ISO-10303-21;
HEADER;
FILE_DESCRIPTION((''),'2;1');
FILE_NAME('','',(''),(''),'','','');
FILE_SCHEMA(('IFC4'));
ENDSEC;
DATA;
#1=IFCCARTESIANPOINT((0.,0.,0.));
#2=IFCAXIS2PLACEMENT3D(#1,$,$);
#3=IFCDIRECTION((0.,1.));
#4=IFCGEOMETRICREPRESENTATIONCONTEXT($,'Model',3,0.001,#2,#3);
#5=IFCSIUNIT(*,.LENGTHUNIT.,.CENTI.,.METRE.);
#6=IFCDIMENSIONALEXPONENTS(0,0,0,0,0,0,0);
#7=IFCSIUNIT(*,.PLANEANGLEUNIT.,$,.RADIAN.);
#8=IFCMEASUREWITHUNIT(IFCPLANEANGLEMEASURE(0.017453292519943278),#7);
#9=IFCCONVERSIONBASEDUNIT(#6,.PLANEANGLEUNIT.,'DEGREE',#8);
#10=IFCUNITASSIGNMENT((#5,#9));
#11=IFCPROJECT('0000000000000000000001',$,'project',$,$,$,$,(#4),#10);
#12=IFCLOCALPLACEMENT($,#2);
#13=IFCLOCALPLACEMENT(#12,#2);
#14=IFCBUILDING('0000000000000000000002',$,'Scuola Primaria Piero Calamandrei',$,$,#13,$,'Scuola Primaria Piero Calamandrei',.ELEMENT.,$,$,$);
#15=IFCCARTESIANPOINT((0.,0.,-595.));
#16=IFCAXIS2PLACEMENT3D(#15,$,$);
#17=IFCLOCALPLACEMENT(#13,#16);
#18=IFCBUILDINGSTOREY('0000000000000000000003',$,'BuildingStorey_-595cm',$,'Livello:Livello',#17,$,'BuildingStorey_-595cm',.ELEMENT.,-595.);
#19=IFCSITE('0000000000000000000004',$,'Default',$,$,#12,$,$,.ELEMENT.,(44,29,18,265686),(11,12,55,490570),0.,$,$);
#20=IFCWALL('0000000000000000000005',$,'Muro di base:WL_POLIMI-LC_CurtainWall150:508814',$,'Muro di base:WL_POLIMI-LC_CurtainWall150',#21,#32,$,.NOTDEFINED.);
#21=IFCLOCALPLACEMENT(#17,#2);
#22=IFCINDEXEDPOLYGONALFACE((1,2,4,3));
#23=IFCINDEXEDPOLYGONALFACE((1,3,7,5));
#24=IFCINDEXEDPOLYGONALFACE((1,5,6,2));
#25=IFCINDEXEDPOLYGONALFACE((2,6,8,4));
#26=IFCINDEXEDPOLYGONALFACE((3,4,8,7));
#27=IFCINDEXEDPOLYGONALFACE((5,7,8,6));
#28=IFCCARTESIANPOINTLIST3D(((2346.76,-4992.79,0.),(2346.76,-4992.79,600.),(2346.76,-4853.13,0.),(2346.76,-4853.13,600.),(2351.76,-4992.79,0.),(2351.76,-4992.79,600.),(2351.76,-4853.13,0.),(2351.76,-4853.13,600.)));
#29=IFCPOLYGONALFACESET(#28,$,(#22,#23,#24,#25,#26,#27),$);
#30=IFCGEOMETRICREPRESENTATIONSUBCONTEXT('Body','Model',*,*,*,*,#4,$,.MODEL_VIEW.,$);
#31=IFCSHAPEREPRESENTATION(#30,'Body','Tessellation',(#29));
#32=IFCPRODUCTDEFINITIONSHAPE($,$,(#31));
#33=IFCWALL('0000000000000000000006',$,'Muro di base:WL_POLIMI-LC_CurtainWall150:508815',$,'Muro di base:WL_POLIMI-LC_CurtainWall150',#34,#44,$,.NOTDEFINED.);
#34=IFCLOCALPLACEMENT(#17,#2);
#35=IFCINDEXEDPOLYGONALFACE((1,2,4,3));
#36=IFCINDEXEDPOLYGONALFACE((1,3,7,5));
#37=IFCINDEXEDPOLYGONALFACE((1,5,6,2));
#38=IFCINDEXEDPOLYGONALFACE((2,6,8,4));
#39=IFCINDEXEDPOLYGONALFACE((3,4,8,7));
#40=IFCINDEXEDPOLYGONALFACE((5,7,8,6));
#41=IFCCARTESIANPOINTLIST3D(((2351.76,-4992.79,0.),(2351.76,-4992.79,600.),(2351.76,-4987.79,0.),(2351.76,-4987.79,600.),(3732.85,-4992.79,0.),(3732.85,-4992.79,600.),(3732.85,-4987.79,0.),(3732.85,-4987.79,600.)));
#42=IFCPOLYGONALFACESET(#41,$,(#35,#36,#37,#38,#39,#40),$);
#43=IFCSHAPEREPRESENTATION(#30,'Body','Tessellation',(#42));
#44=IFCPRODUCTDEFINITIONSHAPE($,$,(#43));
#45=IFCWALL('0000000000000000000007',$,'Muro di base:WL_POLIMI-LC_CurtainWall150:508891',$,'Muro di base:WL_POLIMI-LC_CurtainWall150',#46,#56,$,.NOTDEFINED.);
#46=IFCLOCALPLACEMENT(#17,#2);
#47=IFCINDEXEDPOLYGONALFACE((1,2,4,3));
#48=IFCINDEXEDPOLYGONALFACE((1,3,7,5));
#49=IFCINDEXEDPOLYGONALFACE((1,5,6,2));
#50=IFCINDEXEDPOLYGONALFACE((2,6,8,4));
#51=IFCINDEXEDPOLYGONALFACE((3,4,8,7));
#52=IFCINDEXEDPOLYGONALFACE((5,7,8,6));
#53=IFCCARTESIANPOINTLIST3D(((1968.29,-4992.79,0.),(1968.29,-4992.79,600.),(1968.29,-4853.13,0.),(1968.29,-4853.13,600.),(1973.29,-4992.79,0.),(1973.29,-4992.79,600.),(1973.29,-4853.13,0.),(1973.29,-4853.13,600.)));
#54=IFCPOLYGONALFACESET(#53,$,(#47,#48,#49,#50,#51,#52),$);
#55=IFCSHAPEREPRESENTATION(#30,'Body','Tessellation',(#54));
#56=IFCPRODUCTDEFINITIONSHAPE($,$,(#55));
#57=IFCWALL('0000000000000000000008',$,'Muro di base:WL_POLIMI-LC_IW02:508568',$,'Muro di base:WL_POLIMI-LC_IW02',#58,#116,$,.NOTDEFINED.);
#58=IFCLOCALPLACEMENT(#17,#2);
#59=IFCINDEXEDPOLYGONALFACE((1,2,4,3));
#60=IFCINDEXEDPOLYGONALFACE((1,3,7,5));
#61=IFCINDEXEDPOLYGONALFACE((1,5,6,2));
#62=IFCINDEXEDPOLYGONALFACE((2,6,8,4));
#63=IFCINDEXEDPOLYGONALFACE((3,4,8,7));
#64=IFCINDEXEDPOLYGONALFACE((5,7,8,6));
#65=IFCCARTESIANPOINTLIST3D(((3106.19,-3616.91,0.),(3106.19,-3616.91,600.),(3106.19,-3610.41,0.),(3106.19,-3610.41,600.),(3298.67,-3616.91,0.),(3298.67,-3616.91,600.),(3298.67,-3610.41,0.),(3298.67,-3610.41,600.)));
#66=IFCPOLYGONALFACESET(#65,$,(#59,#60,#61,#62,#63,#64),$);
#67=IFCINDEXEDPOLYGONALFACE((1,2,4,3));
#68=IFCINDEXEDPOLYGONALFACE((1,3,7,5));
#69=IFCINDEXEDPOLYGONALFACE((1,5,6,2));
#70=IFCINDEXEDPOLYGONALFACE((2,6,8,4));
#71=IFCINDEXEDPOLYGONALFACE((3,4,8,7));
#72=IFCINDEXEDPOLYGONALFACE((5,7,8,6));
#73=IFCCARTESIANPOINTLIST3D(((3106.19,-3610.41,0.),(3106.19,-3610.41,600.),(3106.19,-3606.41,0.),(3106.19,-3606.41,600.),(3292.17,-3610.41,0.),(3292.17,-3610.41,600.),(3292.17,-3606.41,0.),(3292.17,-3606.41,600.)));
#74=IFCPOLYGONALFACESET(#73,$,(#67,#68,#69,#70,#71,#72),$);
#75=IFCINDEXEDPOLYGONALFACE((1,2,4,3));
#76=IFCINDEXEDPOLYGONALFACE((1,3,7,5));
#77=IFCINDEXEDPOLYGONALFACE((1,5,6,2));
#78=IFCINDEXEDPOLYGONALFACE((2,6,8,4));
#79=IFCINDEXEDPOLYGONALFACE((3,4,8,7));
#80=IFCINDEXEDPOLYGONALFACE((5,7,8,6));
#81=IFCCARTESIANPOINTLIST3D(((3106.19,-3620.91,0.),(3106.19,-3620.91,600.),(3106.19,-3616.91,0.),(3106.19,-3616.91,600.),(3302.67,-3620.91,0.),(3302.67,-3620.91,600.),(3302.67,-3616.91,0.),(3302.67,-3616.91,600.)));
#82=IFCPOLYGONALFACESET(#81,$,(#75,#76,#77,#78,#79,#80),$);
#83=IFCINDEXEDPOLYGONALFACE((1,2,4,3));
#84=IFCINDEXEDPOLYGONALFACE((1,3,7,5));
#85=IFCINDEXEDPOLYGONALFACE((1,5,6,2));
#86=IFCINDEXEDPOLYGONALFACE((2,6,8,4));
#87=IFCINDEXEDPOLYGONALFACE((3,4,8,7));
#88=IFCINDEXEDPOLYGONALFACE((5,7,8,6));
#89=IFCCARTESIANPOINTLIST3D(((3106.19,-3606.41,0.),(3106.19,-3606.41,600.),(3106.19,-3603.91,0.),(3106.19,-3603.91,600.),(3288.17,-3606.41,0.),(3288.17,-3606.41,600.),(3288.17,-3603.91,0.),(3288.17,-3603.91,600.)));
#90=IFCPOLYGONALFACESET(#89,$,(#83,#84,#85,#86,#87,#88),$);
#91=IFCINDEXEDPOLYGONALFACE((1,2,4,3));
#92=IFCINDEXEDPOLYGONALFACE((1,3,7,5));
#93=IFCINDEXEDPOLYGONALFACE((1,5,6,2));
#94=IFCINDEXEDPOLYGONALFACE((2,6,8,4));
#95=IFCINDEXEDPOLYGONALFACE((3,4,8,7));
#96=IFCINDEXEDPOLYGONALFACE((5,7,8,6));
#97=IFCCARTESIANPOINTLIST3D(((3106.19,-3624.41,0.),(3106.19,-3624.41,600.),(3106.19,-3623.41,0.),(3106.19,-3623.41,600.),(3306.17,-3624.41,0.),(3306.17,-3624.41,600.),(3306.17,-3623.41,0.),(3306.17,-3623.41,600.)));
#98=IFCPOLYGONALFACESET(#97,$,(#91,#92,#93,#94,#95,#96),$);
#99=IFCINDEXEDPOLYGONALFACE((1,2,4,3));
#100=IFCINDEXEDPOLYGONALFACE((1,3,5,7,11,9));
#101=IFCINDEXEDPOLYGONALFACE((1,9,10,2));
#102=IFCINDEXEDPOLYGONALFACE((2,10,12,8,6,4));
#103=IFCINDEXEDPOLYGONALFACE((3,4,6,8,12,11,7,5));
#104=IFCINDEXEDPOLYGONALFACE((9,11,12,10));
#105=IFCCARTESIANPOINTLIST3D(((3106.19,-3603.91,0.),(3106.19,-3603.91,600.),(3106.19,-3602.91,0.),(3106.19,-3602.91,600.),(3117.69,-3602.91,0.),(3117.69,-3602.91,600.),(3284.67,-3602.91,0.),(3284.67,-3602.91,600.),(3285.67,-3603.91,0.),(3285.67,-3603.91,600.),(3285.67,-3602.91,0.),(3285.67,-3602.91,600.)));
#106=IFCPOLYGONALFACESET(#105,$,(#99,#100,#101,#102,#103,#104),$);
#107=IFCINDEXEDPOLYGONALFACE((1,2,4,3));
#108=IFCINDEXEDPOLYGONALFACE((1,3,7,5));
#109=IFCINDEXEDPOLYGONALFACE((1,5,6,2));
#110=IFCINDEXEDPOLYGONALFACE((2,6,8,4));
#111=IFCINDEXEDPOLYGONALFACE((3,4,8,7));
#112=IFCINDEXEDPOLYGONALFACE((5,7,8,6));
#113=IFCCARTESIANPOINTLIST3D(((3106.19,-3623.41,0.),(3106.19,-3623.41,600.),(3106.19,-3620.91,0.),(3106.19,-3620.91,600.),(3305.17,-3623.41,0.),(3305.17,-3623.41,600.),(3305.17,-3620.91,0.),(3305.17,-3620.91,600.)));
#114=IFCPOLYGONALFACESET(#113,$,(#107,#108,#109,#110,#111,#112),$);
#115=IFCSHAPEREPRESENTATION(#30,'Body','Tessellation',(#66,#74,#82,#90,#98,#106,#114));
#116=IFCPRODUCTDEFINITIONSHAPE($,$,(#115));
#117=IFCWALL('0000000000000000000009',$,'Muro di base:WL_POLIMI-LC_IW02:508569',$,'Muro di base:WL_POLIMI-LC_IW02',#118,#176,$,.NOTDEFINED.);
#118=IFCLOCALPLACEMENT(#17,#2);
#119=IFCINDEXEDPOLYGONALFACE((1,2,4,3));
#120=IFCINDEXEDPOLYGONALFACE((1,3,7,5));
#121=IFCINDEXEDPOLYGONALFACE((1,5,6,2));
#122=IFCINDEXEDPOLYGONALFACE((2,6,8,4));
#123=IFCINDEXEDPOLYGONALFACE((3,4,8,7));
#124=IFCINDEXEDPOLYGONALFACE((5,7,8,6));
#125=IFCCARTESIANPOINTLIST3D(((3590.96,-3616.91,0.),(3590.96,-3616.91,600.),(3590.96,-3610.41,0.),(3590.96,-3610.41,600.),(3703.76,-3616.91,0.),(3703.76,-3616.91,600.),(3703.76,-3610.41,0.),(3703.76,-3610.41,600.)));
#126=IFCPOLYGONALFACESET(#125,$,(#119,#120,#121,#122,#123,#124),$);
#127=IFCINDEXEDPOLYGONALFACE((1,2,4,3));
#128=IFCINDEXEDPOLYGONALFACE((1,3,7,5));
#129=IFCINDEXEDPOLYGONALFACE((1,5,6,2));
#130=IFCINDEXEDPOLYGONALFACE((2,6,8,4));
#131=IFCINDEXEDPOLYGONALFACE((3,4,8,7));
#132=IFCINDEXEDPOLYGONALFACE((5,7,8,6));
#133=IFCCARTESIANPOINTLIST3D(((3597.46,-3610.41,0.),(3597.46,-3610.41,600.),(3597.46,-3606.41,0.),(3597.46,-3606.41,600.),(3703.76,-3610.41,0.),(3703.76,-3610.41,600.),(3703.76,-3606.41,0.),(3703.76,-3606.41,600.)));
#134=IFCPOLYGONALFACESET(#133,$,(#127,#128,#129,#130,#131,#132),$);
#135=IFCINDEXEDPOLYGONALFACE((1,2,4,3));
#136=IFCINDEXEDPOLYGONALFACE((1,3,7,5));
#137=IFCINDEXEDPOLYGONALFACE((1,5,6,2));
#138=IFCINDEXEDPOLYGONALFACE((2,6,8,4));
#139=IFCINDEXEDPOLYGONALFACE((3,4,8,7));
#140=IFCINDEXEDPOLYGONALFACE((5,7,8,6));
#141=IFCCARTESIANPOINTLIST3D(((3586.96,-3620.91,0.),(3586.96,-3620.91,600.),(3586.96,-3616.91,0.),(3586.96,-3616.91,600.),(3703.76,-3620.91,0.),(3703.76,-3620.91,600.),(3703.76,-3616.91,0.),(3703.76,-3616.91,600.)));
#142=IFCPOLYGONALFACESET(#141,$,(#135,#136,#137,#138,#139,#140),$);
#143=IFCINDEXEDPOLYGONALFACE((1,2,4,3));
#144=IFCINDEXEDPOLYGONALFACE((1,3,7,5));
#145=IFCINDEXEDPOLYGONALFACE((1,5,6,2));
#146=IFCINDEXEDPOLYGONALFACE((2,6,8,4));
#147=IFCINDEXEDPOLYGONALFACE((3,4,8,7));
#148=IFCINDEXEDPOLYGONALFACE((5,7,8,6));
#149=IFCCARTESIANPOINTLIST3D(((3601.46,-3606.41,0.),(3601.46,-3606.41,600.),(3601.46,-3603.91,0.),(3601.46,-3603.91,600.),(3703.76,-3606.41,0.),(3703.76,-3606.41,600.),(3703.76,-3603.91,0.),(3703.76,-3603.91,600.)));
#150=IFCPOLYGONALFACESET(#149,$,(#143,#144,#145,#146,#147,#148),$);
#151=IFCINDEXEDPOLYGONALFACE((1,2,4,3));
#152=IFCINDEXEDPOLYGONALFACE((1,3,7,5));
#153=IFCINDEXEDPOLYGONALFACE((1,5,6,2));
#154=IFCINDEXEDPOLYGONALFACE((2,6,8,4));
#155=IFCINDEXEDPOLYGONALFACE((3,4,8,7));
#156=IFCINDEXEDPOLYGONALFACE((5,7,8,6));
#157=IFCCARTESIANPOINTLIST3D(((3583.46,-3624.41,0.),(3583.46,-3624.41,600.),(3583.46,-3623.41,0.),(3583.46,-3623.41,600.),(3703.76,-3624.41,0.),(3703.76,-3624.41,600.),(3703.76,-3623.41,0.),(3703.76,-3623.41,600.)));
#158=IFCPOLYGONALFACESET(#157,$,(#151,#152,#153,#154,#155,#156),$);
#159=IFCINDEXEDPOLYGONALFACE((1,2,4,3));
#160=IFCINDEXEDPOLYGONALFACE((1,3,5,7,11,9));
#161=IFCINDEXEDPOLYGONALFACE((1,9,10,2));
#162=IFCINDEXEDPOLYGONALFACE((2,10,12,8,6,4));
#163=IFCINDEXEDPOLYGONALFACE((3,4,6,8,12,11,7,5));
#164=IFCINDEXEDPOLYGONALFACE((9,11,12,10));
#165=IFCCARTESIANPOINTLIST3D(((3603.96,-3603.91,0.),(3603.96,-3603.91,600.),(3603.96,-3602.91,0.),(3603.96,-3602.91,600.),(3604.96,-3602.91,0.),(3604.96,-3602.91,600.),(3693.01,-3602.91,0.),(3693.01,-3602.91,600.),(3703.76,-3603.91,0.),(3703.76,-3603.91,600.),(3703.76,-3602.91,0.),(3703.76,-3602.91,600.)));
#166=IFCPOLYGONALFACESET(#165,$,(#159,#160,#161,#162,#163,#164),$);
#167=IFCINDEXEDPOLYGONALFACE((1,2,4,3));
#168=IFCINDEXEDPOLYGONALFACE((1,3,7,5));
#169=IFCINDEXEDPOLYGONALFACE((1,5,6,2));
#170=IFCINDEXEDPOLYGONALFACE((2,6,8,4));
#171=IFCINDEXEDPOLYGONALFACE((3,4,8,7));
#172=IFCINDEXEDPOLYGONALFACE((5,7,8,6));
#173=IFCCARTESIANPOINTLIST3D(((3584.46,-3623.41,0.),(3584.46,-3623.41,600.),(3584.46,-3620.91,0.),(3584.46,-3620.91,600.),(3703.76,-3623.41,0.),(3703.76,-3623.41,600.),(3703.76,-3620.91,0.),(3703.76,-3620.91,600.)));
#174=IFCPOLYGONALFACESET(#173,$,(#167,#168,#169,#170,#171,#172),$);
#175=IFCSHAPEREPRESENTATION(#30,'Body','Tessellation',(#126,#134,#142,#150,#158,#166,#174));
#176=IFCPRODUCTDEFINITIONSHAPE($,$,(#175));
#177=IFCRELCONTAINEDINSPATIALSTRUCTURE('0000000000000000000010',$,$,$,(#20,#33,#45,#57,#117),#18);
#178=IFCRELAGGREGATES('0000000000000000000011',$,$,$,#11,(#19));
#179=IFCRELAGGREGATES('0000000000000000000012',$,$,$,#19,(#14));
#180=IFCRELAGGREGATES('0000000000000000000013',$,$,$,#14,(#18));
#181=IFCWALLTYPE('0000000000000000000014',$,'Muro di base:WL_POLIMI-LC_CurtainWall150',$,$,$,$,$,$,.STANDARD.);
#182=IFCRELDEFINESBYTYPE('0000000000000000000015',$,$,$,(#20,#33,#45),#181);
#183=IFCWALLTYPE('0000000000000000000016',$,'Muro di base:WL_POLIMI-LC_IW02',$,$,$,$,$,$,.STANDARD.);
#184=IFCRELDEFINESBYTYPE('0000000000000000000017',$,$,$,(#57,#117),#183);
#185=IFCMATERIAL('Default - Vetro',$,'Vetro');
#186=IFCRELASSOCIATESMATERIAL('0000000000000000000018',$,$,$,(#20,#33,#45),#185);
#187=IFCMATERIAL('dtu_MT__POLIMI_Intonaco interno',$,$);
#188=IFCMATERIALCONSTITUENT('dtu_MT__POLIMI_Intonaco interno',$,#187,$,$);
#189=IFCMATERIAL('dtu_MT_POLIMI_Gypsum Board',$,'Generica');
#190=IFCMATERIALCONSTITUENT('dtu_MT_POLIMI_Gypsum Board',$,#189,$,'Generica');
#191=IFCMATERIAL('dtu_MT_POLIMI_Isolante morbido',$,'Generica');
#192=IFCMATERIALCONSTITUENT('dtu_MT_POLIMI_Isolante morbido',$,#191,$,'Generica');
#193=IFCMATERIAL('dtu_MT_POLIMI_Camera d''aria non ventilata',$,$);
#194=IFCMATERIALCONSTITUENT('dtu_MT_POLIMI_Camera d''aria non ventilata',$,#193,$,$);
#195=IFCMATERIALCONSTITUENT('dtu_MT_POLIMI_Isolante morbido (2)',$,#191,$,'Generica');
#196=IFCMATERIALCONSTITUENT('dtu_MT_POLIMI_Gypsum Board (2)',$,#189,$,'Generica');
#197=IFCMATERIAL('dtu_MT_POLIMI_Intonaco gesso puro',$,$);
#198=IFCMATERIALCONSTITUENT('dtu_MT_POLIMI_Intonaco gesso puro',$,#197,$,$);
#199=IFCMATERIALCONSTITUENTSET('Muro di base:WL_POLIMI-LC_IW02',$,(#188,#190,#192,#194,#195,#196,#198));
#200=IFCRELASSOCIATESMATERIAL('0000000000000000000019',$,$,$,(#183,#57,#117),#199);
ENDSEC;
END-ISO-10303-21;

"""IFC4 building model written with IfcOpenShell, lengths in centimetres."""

from ifc_helpers import new_model, entity, si_unit, converted_unit, direction, frame, origin, place, context, subcontext, project, spatial, indexed_curve, outline, extrude, material, constituent, constituent_set, type_object, element, save


model = new_model("IFC4")

# Units and contexts
model_context = context("Model", 3, precision=0.001, world=origin(), true_north=direction((0.0, 1.0)))
body_context = subcontext(model_context, "Body", "Model", "MODEL_VIEW")
ifc_project = project(units=[si_unit("LENGTHUNIT", "METRE", prefix="CENTI"), converted_unit("PLANEANGLEUNIT", "DEGREE", entity("IfcPlaneAngleMeasure", 0.017453292519943278), si_unit("PLANEANGLEUNIT", "RADIAN"), dimensions=[0, 0, 0, 0, 0, 0, 0])], contexts=[model_context])

# Site, building, storey
site_placement = place(None, origin())
site = spatial("IfcSite", under=ifc_project, at=site_placement, Name="Default", CompositionType="ELEMENT", RefLatitude=(44, 29, 18, 265686), RefLongitude=(11, 12, 55, 490570), RefElevation=0.0)
building_placement = place(site_placement, origin())
building = spatial("IfcBuilding", under=site, at=building_placement, Name="Scuola Primaria Piero Calamandrei", LongName="Scuola Primaria Piero Calamandrei", CompositionType="ELEMENT")
storey_placement = place(building_placement, frame((0.0, 0.0, -595.0)))
storey = spatial("IfcBuildingStorey", under=building, at=storey_placement, Name="BuildingStorey_-595cm", ObjectType="Livello:Livello", LongName="BuildingStorey_-595cm", CompositionType="ELEMENT", Elevation=-595.0)

# Walls
ifc_material_1 = material(Name="Default - Vetro", Category="Vetro")
wall_type_1 = type_object("IfcWallType", Name="Muro di base:WL_POLIMI-LC_CurtainWall150", PredefinedType="STANDARD")
wall_1_placement = place(storey_placement, frame((2349.26, -4992.79, 0.0), z_axis=(0.0, 0.0, 1.0), x_axis=(0.0, 1.0, 0.0)))
element("IfcWall", 1, at=wall_1_placement, inside=storey, type_object=wall_type_1, material=ifc_material_1, Name="Muro di base:WL_POLIMI-LC_CurtainWall150:508814", ObjectType="Muro di base:WL_POLIMI-LC_CurtainWall150", PredefinedType="NOTDEFINED", context=body_context, shape_type="SweptSolid", body=[
    extrude(outline(indexed_curve([(139.66, 2.5), (0.0, 2.5), (0.0, -2.5), (139.66, -2.5), (139.66, 2.5)], self_intersect=False)), origin(), (0.0, 0.0, 1.0), 600.0),
])
wall_2_placement = place(storey_placement, frame((3732.85, -4990.29, 0.0), z_axis=(0.0, 0.0, 1.0), x_axis=(-1.0, 0.0, 0.0)))
element("IfcWall", 2, at=wall_2_placement, inside=storey, type_object=wall_type_1, material=ifc_material_1, Name="Muro di base:WL_POLIMI-LC_CurtainWall150:508815", ObjectType="Muro di base:WL_POLIMI-LC_CurtainWall150", PredefinedType="NOTDEFINED", context=body_context, shape_type="SweptSolid", body=[
    extrude(outline(indexed_curve([(1381.1, 2.5), (0.0, 2.5), (0.0, -2.5), (1381.1, -2.5), (1381.1, 2.5)], self_intersect=False)), origin(), (0.0, 0.0, 1.0), 600.0),
])
wall_3_placement = place(storey_placement, frame((1970.79, -4992.79, 0.0), z_axis=(0.0, 0.0, 1.0), x_axis=(0.0, 1.0, 0.0)))
element("IfcWall", 3, at=wall_3_placement, inside=storey, type_object=wall_type_1, material=ifc_material_1, Name="Muro di base:WL_POLIMI-LC_CurtainWall150:508891", ObjectType="Muro di base:WL_POLIMI-LC_CurtainWall150", PredefinedType="NOTDEFINED", context=body_context, shape_type="SweptSolid", body=[
    extrude(outline(indexed_curve([(139.66, 2.5), (0.0, 2.5), (0.0, -2.5), (139.66, -2.5), (139.66, 2.5)], self_intersect=False)), origin(), (0.0, 0.0, 1.0), 600.0),
])
ifc_material_2 = material(Name="dtu_MT__POLIMI_Intonaco interno")
ifc_constituent_1 = constituent(ifc_material_2, Name="dtu_MT__POLIMI_Intonaco interno")
ifc_material_3 = material(Name="dtu_MT_POLIMI_Gypsum Board", Category="Generica")
ifc_constituent_2 = constituent(ifc_material_3, Name="dtu_MT_POLIMI_Gypsum Board", Category="Generica")
ifc_material_4 = material(Name="dtu_MT_POLIMI_Isolante morbido", Category="Generica")
ifc_constituent_3 = constituent(ifc_material_4, Name="dtu_MT_POLIMI_Isolante morbido", Category="Generica")
ifc_material_5 = material(Name="dtu_MT_POLIMI_Camera d'aria non ventilata")
ifc_constituent_4 = constituent(ifc_material_5, Name="dtu_MT_POLIMI_Camera d'aria non ventilata")
ifc_constituent_5 = constituent(ifc_material_4, Name="dtu_MT_POLIMI_Isolante morbido (2)", Category="Generica")
ifc_constituent_6 = constituent(ifc_material_3, Name="dtu_MT_POLIMI_Gypsum Board (2)", Category="Generica")
ifc_material_6 = material(Name="dtu_MT_POLIMI_Intonaco gesso puro")
ifc_constituent_7 = constituent(ifc_material_6, Name="dtu_MT_POLIMI_Intonaco gesso puro")
ifc_constituent_set_1 = constituent_set(constituents=[ifc_constituent_1, ifc_constituent_2, ifc_constituent_3, ifc_constituent_4, ifc_constituent_5, ifc_constituent_6, ifc_constituent_7], Name="Muro di base:WL_POLIMI-LC_IW02")
wall_type_2 = type_object("IfcWallType", Name="Muro di base:WL_POLIMI-LC_IW02", PredefinedType="STANDARD", material=ifc_constituent_set_1)
wall_4_placement = place(storey_placement, frame((3106.19, -3613.66, 0.0)))
element("IfcWall", 4, at=wall_4_placement, inside=storey, type_object=wall_type_2, material=ifc_constituent_set_1, Name="Muro di base:WL_POLIMI-LC_IW02:508568", ObjectType="Muro di base:WL_POLIMI-LC_IW02", PredefinedType="NOTDEFINED", context=body_context, shape_type="SweptSolid", body=[
    extrude(outline(indexed_curve([(-96.24, -3.25), (96.24, -3.25), (96.24, 3.25), (-96.24, 3.25), (-96.24, -3.25)], self_intersect=False)), frame((96.24, 0.0, 0.0)), (0.0, 0.0, 1.0), 600.0),
    extrude(outline(indexed_curve([(-92.99, -2.0), (92.99, -2.0), (92.99, 2.0), (-92.99, 2.0), (-92.99, -2.0)], self_intersect=False)), frame((92.99, 5.25, 0.0)), (0.0, 0.0, 1.0), 600.0),
    extrude(outline(indexed_curve([(-98.24, -2.0), (98.24, -2.0), (98.24, 2.0), (-98.24, 2.0), (-98.24, -2.0)], self_intersect=False)), frame((98.24, -5.25, 0.0)), (0.0, 0.0, 1.0), 600.0),
    extrude(outline(indexed_curve([(-90.99, -1.25), (90.99, -1.25), (90.99, 1.25), (-90.99, 1.25), (-90.99, -1.25)], self_intersect=False)), frame((90.99, 8.5, 0.0)), (0.0, 0.0, 1.0), 600.0),
    extrude(outline(indexed_curve([(-0.5, -99.99), (0.5, -99.99), (0.5, 99.99), (-0.5, 99.99), (-0.5, -99.99)], self_intersect=False)), frame((99.99, -10.25, 0.0), z_axis=(0.0, 0.0, 1.0), x_axis=(0.0, 1.0, 0.0)), (0.0, 0.0, 1.0), 600.0),
    extrude(outline(indexed_curve([(-86.99, -0.33), (79.99, -0.33), (91.49, -0.33), (91.49, 0.67), (-87.99, 0.67), (-87.99, -0.33), (-86.99, -0.33)], self_intersect=False)), frame((91.49, 10.42, 0.0), z_axis=(0.0, 0.0, 1.0), x_axis=(-1.0, 0.0, 0.0)), (0.0, 0.0, 1.0), 600.0),
    extrude(outline(indexed_curve([(-99.49, -1.25), (99.49, -1.25), (99.49, 1.25), (-99.49, 1.25), (-99.49, -1.25)], self_intersect=False)), frame((99.49, -8.5, 0.0)), (0.0, 0.0, 1.0), 600.0),
])
wall_5_placement = place(storey_placement, frame((3583.46, -3613.66, 0.0)))
element("IfcWall", 5, at=wall_5_placement, inside=storey, type_object=wall_type_2, material=ifc_constituent_set_1, Name="Muro di base:WL_POLIMI-LC_IW02:508569", ObjectType="Muro di base:WL_POLIMI-LC_IW02", PredefinedType="NOTDEFINED", context=body_context, shape_type="SweptSolid", body=[
    extrude(outline(indexed_curve([(-56.4, -3.25), (56.4, -3.25), (56.4, 3.25), (-56.4, 3.25), (-56.4, -3.25)], self_intersect=False)), frame((63.9, 0.0, 0.0)), (0.0, 0.0, 1.0), 600.0),
    extrude(outline(indexed_curve([(-53.15, -2.0), (53.15, -2.0), (53.15, 2.0), (-53.15, 2.0), (-53.15, -2.0)], self_intersect=False)), frame((67.15, 5.25, 0.0)), (0.0, 0.0, 1.0), 600.0),
    extrude(outline(indexed_curve([(-58.4, -2.0), (58.4, -2.0), (58.4, 2.0), (-58.4, 2.0), (-58.4, -2.0)], self_intersect=False)), frame((61.9, -5.25, 0.0)), (0.0, 0.0, 1.0), 600.0),
    extrude(outline(indexed_curve([(-51.15, -1.25), (51.15, -1.25), (51.15, 1.25), (-51.15, 1.25), (-51.15, -1.25)], self_intersect=False)), frame((69.15, 8.5, 0.0)), (0.0, 0.0, 1.0), 600.0),
    extrude(outline(indexed_curve([(-0.5, -60.15), (0.5, -60.15), (0.5, 60.15), (-0.5, 60.15), (-0.5, -60.15)], self_intersect=False)), frame((60.15, -10.25, 0.0), z_axis=(0.0, 0.0, 1.0), x_axis=(0.0, 1.0, 0.0)), (0.0, 0.0, 1.0), 600.0),
    extrude(outline(indexed_curve([(-40.78, -0.33), (47.28, -0.33), (48.28, -0.33), (48.28, 0.67), (-51.53, 0.67), (-51.53, -0.33), (-40.78, -0.33)], self_intersect=False)), frame((68.78, 10.42, 0.0), z_axis=(0.0, 0.0, 1.0), x_axis=(-1.0, 0.0, 0.0)), (0.0, 0.0, 1.0), 600.0),
    extrude(outline(indexed_curve([(-59.65, -1.25), (59.65, -1.25), (59.65, 1.25), (-59.65, 1.25), (-59.65, -1.25)], self_intersect=False)), frame((60.65, -8.5, 0.0)), (0.0, 0.0, 1.0), 600.0),
])

save(model, "model.ifc")
